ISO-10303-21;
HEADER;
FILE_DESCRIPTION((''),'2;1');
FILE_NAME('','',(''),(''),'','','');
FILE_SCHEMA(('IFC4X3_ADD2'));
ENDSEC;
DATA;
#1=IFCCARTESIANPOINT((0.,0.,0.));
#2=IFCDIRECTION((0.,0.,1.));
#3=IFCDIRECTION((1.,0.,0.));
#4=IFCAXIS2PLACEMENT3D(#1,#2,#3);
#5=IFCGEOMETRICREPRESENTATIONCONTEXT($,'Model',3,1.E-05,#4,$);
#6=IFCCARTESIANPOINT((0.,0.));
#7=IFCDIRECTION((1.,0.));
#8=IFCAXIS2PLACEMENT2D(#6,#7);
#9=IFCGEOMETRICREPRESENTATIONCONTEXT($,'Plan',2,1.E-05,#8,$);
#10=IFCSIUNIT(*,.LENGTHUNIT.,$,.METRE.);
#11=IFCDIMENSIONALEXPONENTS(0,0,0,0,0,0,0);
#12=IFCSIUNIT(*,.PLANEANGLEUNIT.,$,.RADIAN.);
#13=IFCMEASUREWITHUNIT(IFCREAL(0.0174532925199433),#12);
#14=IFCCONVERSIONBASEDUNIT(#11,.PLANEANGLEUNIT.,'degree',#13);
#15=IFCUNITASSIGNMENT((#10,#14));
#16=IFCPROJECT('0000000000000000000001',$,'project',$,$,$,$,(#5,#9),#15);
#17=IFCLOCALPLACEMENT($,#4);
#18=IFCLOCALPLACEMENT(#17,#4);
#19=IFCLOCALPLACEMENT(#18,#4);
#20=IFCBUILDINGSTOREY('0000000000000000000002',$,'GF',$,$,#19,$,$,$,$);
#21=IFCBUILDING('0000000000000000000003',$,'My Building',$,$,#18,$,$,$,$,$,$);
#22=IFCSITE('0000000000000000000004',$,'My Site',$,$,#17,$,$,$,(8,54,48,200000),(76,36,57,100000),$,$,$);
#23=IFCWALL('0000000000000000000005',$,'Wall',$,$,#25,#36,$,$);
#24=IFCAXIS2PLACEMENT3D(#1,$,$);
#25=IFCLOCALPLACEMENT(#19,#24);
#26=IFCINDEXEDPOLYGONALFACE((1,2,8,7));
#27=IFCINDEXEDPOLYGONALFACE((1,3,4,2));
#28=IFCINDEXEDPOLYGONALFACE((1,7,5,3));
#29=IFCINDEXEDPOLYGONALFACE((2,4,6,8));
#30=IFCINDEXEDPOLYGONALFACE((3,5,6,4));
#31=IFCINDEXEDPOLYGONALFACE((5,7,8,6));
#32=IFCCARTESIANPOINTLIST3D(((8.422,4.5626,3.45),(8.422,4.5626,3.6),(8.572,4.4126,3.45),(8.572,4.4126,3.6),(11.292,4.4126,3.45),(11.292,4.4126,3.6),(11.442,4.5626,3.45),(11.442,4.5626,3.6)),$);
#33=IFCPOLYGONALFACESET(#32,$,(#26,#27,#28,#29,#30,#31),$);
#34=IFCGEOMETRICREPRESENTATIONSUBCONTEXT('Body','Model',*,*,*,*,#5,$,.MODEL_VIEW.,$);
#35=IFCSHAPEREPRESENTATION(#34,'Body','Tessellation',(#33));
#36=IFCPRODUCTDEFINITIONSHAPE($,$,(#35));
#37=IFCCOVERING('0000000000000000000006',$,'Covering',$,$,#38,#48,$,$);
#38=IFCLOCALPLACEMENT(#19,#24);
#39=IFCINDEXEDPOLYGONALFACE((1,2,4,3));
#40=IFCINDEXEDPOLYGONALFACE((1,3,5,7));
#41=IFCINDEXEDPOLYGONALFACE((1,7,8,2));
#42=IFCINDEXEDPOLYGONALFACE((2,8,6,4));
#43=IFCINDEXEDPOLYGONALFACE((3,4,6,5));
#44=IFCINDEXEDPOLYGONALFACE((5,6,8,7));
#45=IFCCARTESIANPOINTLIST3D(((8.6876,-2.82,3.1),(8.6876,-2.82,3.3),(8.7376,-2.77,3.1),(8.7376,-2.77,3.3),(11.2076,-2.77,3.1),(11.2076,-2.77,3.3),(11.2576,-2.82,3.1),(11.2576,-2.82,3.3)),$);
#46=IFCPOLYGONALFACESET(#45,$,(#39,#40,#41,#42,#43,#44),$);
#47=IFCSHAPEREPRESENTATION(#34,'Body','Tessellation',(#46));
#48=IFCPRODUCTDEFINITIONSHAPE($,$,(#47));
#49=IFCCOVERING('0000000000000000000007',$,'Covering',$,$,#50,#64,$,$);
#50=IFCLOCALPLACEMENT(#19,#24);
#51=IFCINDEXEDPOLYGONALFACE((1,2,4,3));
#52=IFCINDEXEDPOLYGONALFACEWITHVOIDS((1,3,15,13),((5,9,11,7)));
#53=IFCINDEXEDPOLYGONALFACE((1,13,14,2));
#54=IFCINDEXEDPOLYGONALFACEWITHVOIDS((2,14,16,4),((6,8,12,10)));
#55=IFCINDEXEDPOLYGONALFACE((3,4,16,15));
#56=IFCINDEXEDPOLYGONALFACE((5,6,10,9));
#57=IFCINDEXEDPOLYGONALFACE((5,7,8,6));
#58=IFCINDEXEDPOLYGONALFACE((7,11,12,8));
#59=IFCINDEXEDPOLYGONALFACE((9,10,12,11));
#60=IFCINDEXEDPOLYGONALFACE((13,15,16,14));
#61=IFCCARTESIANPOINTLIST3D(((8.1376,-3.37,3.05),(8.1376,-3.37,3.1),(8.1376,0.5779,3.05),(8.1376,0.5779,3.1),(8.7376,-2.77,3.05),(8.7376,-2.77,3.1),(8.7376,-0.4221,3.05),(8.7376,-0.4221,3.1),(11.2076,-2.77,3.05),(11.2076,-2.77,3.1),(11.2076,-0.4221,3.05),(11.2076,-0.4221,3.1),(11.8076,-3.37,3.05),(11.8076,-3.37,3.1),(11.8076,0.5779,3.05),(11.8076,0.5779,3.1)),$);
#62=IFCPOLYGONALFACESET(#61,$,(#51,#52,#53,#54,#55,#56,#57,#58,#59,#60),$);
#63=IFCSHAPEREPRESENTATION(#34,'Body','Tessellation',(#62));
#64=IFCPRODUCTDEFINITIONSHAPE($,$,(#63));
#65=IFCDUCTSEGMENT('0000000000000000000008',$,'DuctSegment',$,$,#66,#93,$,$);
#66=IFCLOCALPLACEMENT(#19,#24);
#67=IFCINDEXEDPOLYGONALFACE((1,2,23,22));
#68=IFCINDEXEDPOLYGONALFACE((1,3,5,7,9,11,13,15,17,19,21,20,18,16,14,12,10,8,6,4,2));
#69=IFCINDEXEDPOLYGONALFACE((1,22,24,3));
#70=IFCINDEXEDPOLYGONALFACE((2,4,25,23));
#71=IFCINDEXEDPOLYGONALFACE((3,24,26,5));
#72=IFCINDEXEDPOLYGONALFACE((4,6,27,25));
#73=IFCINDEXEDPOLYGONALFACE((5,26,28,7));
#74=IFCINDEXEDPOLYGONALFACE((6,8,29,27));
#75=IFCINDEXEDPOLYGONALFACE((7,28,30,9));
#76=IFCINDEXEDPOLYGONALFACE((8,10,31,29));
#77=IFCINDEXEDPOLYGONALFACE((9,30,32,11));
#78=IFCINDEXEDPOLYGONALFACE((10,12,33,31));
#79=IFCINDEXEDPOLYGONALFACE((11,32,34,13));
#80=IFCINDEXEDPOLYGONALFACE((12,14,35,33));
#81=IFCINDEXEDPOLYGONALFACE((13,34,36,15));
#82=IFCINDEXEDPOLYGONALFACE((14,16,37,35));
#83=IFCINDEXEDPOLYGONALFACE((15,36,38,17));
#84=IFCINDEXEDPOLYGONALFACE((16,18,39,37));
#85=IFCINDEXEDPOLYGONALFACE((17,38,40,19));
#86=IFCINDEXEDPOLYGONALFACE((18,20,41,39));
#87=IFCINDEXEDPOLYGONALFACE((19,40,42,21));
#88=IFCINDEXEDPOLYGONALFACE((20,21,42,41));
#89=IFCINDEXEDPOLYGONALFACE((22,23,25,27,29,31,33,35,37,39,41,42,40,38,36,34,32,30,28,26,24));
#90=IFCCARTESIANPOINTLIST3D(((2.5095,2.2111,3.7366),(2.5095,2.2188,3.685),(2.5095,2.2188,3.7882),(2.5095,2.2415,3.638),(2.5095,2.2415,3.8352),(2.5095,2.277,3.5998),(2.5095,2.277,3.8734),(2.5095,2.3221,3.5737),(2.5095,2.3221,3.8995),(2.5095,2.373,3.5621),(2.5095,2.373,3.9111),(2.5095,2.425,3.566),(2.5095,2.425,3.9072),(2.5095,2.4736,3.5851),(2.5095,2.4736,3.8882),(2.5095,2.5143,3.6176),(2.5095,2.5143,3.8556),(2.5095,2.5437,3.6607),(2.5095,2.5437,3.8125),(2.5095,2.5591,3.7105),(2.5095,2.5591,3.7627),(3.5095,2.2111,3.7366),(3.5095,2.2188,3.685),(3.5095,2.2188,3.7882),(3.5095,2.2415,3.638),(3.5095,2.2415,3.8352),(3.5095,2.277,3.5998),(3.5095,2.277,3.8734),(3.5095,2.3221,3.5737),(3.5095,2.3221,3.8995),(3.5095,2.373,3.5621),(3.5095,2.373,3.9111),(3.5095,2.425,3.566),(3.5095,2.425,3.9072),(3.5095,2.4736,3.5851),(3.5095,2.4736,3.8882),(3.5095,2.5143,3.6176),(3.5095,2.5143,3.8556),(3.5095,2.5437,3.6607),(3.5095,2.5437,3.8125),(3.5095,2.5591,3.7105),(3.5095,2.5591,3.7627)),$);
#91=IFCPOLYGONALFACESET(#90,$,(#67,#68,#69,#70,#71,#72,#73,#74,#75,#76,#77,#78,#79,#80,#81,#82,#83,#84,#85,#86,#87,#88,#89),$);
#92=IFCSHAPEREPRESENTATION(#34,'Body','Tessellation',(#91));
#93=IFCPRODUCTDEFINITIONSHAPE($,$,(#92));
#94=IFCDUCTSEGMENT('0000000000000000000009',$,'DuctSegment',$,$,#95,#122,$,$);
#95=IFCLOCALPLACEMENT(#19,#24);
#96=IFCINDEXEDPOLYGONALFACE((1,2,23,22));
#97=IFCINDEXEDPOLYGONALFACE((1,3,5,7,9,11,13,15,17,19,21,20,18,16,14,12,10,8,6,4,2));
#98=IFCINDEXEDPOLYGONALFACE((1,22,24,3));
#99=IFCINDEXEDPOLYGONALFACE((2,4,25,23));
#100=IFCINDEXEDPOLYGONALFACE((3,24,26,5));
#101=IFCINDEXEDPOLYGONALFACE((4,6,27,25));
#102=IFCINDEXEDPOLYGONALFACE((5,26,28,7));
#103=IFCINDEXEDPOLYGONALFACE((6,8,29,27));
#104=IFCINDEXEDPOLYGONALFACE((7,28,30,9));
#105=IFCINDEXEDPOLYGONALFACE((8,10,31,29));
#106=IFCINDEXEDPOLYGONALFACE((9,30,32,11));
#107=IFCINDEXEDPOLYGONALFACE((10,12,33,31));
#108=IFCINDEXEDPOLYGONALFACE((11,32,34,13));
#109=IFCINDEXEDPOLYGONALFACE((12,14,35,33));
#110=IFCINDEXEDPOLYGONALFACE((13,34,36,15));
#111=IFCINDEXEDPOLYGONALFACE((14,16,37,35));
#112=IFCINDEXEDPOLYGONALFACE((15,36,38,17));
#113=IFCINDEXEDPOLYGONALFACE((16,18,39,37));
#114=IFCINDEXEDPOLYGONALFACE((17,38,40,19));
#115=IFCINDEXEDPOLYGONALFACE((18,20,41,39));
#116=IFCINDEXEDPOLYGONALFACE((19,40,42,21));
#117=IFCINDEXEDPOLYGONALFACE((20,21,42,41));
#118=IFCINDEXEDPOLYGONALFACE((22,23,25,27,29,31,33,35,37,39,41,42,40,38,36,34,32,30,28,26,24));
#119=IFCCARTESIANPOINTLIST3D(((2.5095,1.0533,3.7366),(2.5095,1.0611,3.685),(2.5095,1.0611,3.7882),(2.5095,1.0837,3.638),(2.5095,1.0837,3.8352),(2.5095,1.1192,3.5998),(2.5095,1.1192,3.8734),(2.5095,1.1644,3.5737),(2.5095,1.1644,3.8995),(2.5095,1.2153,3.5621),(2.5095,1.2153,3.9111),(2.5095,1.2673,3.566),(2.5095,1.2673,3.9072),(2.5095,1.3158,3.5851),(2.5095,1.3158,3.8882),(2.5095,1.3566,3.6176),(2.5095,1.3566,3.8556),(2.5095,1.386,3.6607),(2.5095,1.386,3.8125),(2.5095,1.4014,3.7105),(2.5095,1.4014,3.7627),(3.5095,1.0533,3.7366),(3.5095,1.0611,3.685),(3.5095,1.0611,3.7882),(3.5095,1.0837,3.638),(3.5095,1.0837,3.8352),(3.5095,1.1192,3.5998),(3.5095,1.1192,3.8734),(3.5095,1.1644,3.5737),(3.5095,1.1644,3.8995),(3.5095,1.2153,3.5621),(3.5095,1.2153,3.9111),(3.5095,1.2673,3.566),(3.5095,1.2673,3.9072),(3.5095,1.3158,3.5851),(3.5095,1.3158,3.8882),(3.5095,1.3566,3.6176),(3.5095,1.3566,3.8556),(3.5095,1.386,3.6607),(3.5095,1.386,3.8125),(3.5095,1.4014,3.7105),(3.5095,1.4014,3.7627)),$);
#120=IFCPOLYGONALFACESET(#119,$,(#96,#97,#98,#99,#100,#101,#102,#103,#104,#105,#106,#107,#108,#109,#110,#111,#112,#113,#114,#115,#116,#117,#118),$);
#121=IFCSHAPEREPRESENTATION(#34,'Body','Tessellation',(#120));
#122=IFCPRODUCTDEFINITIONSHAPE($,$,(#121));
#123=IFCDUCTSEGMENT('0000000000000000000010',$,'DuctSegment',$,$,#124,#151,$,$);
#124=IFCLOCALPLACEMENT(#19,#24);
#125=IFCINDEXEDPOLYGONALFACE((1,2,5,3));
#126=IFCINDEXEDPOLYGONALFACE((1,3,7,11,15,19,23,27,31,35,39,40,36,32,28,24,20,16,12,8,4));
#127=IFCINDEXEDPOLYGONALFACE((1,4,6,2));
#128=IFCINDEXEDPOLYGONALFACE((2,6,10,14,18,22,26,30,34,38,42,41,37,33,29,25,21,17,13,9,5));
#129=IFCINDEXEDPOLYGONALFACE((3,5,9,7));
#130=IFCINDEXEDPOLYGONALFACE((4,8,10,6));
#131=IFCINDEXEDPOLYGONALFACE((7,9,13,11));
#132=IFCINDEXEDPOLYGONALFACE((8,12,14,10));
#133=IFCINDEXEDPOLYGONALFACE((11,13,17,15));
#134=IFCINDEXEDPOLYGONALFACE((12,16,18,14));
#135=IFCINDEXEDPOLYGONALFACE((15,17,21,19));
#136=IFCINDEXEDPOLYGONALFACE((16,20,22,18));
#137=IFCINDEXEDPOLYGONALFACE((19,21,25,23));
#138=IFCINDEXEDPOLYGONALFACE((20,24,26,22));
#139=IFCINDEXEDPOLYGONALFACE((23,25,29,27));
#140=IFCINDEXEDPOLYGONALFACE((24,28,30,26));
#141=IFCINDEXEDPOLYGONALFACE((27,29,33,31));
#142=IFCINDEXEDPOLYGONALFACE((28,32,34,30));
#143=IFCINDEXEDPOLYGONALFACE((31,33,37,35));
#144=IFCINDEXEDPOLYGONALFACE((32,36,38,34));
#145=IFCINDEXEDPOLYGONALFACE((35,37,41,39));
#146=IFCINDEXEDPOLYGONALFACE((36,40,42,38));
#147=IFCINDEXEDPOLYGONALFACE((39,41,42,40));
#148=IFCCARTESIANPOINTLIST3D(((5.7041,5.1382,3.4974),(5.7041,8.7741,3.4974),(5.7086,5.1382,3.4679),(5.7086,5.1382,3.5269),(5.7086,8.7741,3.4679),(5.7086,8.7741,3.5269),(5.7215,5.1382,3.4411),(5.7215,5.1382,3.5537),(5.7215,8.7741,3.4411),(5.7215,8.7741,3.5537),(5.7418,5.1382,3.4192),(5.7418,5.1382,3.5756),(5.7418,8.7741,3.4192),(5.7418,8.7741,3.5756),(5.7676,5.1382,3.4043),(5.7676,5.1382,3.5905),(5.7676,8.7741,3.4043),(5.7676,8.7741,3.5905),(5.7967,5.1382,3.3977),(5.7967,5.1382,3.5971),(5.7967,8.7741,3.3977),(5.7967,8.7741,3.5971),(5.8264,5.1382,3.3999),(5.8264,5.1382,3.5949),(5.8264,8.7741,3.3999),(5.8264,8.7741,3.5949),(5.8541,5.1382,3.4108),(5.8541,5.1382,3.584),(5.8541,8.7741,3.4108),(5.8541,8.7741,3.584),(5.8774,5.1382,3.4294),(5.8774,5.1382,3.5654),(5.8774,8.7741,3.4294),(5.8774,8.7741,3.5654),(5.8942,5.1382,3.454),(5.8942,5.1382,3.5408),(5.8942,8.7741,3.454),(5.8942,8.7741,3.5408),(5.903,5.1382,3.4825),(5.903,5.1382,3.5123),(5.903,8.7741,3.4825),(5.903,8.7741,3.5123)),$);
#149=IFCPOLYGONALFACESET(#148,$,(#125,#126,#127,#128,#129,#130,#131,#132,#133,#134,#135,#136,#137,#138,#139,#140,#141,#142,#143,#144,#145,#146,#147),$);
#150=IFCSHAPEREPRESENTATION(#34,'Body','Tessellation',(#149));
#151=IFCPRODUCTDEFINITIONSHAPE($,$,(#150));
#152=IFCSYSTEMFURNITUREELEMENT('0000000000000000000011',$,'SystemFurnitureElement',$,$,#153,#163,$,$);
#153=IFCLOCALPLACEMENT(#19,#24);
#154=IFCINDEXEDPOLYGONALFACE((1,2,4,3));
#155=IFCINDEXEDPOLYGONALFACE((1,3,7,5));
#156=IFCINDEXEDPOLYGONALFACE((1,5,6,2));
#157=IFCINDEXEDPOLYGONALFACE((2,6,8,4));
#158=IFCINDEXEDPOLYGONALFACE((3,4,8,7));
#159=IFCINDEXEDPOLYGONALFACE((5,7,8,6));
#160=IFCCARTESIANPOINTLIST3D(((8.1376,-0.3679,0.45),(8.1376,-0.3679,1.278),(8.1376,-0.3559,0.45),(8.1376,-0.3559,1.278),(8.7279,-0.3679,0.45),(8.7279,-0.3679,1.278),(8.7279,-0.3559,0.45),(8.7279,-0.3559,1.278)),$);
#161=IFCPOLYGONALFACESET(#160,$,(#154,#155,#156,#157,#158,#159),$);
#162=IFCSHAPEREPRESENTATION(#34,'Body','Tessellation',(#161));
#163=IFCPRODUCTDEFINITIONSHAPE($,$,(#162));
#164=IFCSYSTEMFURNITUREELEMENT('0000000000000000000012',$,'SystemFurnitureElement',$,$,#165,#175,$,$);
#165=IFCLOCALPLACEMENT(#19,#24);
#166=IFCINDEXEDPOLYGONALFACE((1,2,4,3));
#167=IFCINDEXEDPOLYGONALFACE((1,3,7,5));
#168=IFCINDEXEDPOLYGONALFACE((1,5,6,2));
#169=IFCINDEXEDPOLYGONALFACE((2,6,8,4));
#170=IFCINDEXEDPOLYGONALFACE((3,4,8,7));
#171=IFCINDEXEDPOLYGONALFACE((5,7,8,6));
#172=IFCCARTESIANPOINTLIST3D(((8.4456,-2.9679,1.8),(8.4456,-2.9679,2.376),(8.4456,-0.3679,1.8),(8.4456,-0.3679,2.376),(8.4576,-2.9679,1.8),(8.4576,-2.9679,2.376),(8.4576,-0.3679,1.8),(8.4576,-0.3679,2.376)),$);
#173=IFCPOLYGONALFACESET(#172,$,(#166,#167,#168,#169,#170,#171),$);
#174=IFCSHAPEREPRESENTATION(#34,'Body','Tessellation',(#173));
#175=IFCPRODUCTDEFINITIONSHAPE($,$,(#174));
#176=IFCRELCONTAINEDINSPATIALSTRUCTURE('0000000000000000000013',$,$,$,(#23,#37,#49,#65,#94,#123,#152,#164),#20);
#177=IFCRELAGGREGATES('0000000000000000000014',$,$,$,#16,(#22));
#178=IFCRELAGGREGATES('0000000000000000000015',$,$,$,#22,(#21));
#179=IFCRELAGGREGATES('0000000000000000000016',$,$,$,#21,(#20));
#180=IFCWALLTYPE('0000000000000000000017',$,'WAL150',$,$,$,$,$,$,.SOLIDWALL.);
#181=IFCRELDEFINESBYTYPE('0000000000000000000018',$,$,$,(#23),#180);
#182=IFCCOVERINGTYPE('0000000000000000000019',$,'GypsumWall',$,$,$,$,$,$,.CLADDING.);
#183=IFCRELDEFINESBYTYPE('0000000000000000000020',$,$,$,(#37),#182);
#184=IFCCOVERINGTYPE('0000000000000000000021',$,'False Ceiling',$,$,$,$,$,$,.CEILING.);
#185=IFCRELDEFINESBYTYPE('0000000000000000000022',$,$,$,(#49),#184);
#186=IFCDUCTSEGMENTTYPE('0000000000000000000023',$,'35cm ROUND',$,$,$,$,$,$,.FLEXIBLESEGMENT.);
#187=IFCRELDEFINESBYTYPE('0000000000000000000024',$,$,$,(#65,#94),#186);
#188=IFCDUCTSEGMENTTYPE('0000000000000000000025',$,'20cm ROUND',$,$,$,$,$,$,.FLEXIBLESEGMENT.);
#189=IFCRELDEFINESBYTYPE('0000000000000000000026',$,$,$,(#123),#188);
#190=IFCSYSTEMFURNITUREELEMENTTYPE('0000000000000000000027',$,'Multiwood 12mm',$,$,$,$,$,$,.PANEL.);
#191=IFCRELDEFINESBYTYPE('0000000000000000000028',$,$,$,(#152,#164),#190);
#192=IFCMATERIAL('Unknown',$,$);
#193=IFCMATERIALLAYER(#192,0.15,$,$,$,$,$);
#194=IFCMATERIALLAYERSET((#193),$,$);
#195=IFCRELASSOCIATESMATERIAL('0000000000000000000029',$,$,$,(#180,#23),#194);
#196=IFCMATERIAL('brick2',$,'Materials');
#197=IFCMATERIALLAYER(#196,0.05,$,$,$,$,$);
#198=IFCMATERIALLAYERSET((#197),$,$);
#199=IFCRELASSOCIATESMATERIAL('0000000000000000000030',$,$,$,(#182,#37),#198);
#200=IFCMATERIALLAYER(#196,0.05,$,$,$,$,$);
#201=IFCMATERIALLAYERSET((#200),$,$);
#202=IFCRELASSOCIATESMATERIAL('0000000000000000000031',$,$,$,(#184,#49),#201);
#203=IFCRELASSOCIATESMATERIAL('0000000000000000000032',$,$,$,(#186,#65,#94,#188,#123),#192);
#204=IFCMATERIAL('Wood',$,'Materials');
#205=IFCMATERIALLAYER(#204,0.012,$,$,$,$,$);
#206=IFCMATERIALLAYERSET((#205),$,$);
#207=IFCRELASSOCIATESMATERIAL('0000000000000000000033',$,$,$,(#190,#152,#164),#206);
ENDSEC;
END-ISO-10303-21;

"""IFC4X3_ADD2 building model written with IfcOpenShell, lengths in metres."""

from ifc_helpers import new_model, entity, si_unit, converted_unit, frame, origin_with_axes, origin_2d_with_axis, place, context, subcontext, project, spatial, line, indexed_curve, circle, outline, extrude, material, layer, layer_set, layer_usage, material_profile, profile_set, profile_usage, type_object, element, save


model = new_model("IFC4X3_ADD2")

# Units and contexts
model_context = context("Model", 3, precision=1e-05, world=origin_with_axes())
plan_context = context("Plan", 2, precision=1e-05, world=origin_2d_with_axis())
body_context = subcontext(model_context, "Body", "Model", "MODEL_VIEW")
ifc_project = project(units=[si_unit("LENGTHUNIT", "METRE"), converted_unit("PLANEANGLEUNIT", "degree", entity("IfcReal", 0.0174532925199433), si_unit("PLANEANGLEUNIT", "RADIAN"), dimensions=[0, 0, 0, 0, 0, 0, 0])], contexts=[model_context, plan_context])

# Site, building, storey
site_placement = place(None, origin_with_axes())
site = spatial("IfcSite", under=ifc_project, at=site_placement, Name="My Site", RefLatitude=(8, 54, 48, 200000), RefLongitude=(76, 36, 57, 100000))
building_placement = place(site_placement, origin_with_axes())
building = spatial("IfcBuilding", under=site, at=building_placement, Name="My Building")
storey_placement = place(building_placement, origin_with_axes())
storey = spatial("IfcBuildingStorey", under=building, at=storey_placement, Name="GF")

# Shared definitions
ifc_material_1 = material(Name="Unknown")

# Wall
ifc_layer_1 = layer(ifc_material_1, 0.15)
ifc_layer_set_1 = layer_set([ifc_layer_1])
wall_type_1 = type_object("IfcWallType", Name="WAL150", PredefinedType="SOLIDWALL", material=ifc_layer_set_1)
ifc_layer_usage_1 = layer_usage(ifc_layer_set_1, "AXIS2", "POSITIVE", 0.0)
wall_1_placement = place(storey_placement, frame((8.422, 4.4126, 3.45), z_axis=(0.0, 0.0, 1.0), x_axis=(1.0, 0.0, 0.0)))
element("IfcWall", 1, at=wall_1_placement, inside=storey, type_object=wall_type_1, material=ifc_layer_usage_1, Name="Wall", context=body_context, shape_type="SweptSolid", body=[
    extrude(outline(indexed_curve([(0.15, 0.0), (0.0, 0.15), (3.02, 0.15), (2.87, 0.0)], segments=[line(1, 2, 3, 4, 1)])), origin_with_axes(), (0.0, 0.0, 1.0), 0.15),
])

# Coverings
ifc_material_2 = material(Name="brick2", Category="Materials")
ifc_layer_2 = layer(ifc_material_2, 0.05)
ifc_layer_set_2 = layer_set([ifc_layer_2])
ifc_layer_usage_2 = layer_usage(ifc_layer_set_2, "AXIS2", "POSITIVE", 0.0)
covering_type_1 = type_object("IfcCoveringType", Name="GypsumWall", PredefinedType="CLADDING", material=ifc_layer_set_2)
covering_1_placement = place(storey_placement, frame((8.6876, -2.82, 3.1), z_axis=(0.0, 0.0, 1.0), x_axis=(1.0, 0.0, 0.0)))
element("IfcCovering", 2, at=covering_1_placement, inside=storey, type_object=covering_type_1, material=ifc_layer_usage_2, Name="Covering", context=body_context, shape_type="SweptSolid", body=[
    extrude(outline(indexed_curve([(0.0, 0.0), (0.05, 0.05), (2.52, 0.05), (2.57, 0.0)], segments=[line(1, 2, 3, 4, 1)])), origin_with_axes(), (0.0, 0.0, 1.0), 0.2),
])
ifc_layer_3 = layer(ifc_material_2, 0.05)
ifc_layer_set_3 = layer_set([ifc_layer_3])
ifc_layer_usage_3 = layer_usage(ifc_layer_set_3, "AXIS3", "POSITIVE", -0.05)
covering_type_2 = type_object("IfcCoveringType", Name="False Ceiling", PredefinedType="CEILING", material=ifc_layer_set_3)
covering_2_placement = place(storey_placement, frame((8.1376, -3.37, 3.1), z_axis=(0.0, 0.0, 1.0), x_axis=(1.0, 0.0, 0.0)))
element("IfcCovering", 3, at=covering_2_placement, inside=storey, type_object=covering_type_2, material=ifc_layer_usage_3, Name="Covering", context=body_context, shape_type="SweptSolid", body=[
    extrude(outline(indexed_curve([(0.0, 3.9479), (3.67, 3.9479), (3.67, 0.0), (0.0, 0.0), (0.0, 3.9479)]), holes=[indexed_curve([(0.6, 2.9479), (3.07, 2.9479), (3.07, 0.6), (0.6, 0.6), (0.6, 2.9479)])]), frame((0.0, 0.0, -0.05), z_axis=(0.0, 0.0, 1.0), x_axis=(1.0, 0.0, 0.0)), (0.0, 0.0, 1.0), 0.05),
])

# Duct segments
ifc_material_profile_1 = material_profile(ifc_material_1, circle(Radius=0.175))
ifc_profile_set_1 = profile_set([ifc_material_profile_1])
ifc_profile_usage_1 = profile_usage(ifc_profile_set_1, cardinal=5)
duct_segment_type_1 = type_object("IfcDuctSegmentType", Name="35cm ROUND", PredefinedType="FLEXIBLESEGMENT", material=ifc_profile_set_1)
duct_segment_1_placement = place(storey_placement, frame((3.5095, 2.3861, 3.7366), z_axis=(-1.0, 0.0, 0.0), x_axis=(0.0, -1.0, 0.0)))
element("IfcDuctSegment", 4, at=duct_segment_1_placement, inside=storey, type_object=duct_segment_type_1, material=ifc_profile_usage_1, Name="DuctSegment", context=body_context, shape_type="SweptSolid", body=[
    extrude(circle(Radius=0.175), origin_with_axes(), (0.0, 0.0, 1.0), 1.0),
])
ifc_profile_usage_2 = profile_usage(ifc_profile_set_1, cardinal=5)
duct_segment_2_placement = place(storey_placement, frame((3.5095, 1.2283, 3.7366), z_axis=(-1.0, 0.0, 0.0), x_axis=(0.0, -1.0, 0.0)))
element("IfcDuctSegment", 5, at=duct_segment_2_placement, inside=storey, type_object=duct_segment_type_1, material=ifc_profile_usage_2, Name="DuctSegment", context=body_context, shape_type="SweptSolid", body=[
    extrude(circle(Radius=0.175), origin_with_axes(), (0.0, 0.0, 1.0), 1.0),
])
ifc_material_profile_2 = material_profile(ifc_material_1, circle(Radius=0.1))
ifc_profile_set_2 = profile_set([ifc_material_profile_2])
ifc_profile_usage_3 = profile_usage(ifc_profile_set_2, cardinal=5)
duct_segment_type_2 = type_object("IfcDuctSegmentType", Name="20cm ROUND", PredefinedType="FLEXIBLESEGMENT", material=ifc_profile_set_2)
duct_segment_3_placement = place(storey_placement, frame((5.8041, 5.1382, 3.4974), z_axis=(0.0, 1.0, 0.0), x_axis=(-1.0, 0.0, 0.0)))
element("IfcDuctSegment", 6, at=duct_segment_3_placement, inside=storey, type_object=duct_segment_type_2, material=ifc_profile_usage_3, Name="DuctSegment", context=body_context, shape_type="SweptSolid", body=[
    extrude(circle(Radius=0.1), origin_with_axes(), (0.0, 0.0, 1.0), 3.6358),
])

# System furniture elements
ifc_material_3 = material(Name="Wood", Category="Materials")
ifc_layer_4 = layer(ifc_material_3, 0.012)
ifc_layer_set_4 = layer_set([ifc_layer_4])
ifc_layer_usage_4 = layer_usage(ifc_layer_set_4, "AXIS2", "POSITIVE", 0.0)
system_furniture_element_type = type_object("IfcSystemFurnitureElementType", Name="Multiwood 12mm", PredefinedType="PANEL", material=ifc_layer_set_4)
system_furniture_element_1_placement = place(storey_placement, frame((8.1376, -0.3679, 0.45), z_axis=(0.0, 0.0, 1.0), x_axis=(1.0, 0.0, 0.0)))
element("IfcSystemFurnitureElement", 7, at=system_furniture_element_1_placement, inside=storey, type_object=system_furniture_element_type, material=ifc_layer_usage_4, Name="SystemFurnitureElement", context=body_context, shape_type="SweptSolid", body=[
    extrude(outline(indexed_curve([(0.0, 0.0), (0.0, 0.012), (0.5903, 0.012), (0.5903, 0.0)], segments=[line(1, 2, 3, 4, 1)])), origin_with_axes(), (0.0, 0.0, 1.0), 0.828),
])
ifc_layer_usage_5 = layer_usage(ifc_layer_set_4, "AXIS2", "POSITIVE", 0.0)
system_furniture_element_2_placement = place(storey_placement, frame((8.4456, -0.3679, 1.8), z_axis=(0.0, 0.0, 1.0), x_axis=(0.0, -1.0, 0.0)))
element("IfcSystemFurnitureElement", 8, at=system_furniture_element_2_placement, inside=storey, type_object=system_furniture_element_type, material=ifc_layer_usage_5, Name="SystemFurnitureElement", context=body_context, shape_type="SweptSolid", body=[
    extrude(outline(indexed_curve([(0.0, 0.0), (0.0, 0.012), (2.6, 0.012), (2.6, 0.0)], segments=[line(1, 2, 3, 4, 1)])), origin_with_axes(), (0.0, 0.0, 1.0), 0.576),
])

save(model, "model.ifc")
